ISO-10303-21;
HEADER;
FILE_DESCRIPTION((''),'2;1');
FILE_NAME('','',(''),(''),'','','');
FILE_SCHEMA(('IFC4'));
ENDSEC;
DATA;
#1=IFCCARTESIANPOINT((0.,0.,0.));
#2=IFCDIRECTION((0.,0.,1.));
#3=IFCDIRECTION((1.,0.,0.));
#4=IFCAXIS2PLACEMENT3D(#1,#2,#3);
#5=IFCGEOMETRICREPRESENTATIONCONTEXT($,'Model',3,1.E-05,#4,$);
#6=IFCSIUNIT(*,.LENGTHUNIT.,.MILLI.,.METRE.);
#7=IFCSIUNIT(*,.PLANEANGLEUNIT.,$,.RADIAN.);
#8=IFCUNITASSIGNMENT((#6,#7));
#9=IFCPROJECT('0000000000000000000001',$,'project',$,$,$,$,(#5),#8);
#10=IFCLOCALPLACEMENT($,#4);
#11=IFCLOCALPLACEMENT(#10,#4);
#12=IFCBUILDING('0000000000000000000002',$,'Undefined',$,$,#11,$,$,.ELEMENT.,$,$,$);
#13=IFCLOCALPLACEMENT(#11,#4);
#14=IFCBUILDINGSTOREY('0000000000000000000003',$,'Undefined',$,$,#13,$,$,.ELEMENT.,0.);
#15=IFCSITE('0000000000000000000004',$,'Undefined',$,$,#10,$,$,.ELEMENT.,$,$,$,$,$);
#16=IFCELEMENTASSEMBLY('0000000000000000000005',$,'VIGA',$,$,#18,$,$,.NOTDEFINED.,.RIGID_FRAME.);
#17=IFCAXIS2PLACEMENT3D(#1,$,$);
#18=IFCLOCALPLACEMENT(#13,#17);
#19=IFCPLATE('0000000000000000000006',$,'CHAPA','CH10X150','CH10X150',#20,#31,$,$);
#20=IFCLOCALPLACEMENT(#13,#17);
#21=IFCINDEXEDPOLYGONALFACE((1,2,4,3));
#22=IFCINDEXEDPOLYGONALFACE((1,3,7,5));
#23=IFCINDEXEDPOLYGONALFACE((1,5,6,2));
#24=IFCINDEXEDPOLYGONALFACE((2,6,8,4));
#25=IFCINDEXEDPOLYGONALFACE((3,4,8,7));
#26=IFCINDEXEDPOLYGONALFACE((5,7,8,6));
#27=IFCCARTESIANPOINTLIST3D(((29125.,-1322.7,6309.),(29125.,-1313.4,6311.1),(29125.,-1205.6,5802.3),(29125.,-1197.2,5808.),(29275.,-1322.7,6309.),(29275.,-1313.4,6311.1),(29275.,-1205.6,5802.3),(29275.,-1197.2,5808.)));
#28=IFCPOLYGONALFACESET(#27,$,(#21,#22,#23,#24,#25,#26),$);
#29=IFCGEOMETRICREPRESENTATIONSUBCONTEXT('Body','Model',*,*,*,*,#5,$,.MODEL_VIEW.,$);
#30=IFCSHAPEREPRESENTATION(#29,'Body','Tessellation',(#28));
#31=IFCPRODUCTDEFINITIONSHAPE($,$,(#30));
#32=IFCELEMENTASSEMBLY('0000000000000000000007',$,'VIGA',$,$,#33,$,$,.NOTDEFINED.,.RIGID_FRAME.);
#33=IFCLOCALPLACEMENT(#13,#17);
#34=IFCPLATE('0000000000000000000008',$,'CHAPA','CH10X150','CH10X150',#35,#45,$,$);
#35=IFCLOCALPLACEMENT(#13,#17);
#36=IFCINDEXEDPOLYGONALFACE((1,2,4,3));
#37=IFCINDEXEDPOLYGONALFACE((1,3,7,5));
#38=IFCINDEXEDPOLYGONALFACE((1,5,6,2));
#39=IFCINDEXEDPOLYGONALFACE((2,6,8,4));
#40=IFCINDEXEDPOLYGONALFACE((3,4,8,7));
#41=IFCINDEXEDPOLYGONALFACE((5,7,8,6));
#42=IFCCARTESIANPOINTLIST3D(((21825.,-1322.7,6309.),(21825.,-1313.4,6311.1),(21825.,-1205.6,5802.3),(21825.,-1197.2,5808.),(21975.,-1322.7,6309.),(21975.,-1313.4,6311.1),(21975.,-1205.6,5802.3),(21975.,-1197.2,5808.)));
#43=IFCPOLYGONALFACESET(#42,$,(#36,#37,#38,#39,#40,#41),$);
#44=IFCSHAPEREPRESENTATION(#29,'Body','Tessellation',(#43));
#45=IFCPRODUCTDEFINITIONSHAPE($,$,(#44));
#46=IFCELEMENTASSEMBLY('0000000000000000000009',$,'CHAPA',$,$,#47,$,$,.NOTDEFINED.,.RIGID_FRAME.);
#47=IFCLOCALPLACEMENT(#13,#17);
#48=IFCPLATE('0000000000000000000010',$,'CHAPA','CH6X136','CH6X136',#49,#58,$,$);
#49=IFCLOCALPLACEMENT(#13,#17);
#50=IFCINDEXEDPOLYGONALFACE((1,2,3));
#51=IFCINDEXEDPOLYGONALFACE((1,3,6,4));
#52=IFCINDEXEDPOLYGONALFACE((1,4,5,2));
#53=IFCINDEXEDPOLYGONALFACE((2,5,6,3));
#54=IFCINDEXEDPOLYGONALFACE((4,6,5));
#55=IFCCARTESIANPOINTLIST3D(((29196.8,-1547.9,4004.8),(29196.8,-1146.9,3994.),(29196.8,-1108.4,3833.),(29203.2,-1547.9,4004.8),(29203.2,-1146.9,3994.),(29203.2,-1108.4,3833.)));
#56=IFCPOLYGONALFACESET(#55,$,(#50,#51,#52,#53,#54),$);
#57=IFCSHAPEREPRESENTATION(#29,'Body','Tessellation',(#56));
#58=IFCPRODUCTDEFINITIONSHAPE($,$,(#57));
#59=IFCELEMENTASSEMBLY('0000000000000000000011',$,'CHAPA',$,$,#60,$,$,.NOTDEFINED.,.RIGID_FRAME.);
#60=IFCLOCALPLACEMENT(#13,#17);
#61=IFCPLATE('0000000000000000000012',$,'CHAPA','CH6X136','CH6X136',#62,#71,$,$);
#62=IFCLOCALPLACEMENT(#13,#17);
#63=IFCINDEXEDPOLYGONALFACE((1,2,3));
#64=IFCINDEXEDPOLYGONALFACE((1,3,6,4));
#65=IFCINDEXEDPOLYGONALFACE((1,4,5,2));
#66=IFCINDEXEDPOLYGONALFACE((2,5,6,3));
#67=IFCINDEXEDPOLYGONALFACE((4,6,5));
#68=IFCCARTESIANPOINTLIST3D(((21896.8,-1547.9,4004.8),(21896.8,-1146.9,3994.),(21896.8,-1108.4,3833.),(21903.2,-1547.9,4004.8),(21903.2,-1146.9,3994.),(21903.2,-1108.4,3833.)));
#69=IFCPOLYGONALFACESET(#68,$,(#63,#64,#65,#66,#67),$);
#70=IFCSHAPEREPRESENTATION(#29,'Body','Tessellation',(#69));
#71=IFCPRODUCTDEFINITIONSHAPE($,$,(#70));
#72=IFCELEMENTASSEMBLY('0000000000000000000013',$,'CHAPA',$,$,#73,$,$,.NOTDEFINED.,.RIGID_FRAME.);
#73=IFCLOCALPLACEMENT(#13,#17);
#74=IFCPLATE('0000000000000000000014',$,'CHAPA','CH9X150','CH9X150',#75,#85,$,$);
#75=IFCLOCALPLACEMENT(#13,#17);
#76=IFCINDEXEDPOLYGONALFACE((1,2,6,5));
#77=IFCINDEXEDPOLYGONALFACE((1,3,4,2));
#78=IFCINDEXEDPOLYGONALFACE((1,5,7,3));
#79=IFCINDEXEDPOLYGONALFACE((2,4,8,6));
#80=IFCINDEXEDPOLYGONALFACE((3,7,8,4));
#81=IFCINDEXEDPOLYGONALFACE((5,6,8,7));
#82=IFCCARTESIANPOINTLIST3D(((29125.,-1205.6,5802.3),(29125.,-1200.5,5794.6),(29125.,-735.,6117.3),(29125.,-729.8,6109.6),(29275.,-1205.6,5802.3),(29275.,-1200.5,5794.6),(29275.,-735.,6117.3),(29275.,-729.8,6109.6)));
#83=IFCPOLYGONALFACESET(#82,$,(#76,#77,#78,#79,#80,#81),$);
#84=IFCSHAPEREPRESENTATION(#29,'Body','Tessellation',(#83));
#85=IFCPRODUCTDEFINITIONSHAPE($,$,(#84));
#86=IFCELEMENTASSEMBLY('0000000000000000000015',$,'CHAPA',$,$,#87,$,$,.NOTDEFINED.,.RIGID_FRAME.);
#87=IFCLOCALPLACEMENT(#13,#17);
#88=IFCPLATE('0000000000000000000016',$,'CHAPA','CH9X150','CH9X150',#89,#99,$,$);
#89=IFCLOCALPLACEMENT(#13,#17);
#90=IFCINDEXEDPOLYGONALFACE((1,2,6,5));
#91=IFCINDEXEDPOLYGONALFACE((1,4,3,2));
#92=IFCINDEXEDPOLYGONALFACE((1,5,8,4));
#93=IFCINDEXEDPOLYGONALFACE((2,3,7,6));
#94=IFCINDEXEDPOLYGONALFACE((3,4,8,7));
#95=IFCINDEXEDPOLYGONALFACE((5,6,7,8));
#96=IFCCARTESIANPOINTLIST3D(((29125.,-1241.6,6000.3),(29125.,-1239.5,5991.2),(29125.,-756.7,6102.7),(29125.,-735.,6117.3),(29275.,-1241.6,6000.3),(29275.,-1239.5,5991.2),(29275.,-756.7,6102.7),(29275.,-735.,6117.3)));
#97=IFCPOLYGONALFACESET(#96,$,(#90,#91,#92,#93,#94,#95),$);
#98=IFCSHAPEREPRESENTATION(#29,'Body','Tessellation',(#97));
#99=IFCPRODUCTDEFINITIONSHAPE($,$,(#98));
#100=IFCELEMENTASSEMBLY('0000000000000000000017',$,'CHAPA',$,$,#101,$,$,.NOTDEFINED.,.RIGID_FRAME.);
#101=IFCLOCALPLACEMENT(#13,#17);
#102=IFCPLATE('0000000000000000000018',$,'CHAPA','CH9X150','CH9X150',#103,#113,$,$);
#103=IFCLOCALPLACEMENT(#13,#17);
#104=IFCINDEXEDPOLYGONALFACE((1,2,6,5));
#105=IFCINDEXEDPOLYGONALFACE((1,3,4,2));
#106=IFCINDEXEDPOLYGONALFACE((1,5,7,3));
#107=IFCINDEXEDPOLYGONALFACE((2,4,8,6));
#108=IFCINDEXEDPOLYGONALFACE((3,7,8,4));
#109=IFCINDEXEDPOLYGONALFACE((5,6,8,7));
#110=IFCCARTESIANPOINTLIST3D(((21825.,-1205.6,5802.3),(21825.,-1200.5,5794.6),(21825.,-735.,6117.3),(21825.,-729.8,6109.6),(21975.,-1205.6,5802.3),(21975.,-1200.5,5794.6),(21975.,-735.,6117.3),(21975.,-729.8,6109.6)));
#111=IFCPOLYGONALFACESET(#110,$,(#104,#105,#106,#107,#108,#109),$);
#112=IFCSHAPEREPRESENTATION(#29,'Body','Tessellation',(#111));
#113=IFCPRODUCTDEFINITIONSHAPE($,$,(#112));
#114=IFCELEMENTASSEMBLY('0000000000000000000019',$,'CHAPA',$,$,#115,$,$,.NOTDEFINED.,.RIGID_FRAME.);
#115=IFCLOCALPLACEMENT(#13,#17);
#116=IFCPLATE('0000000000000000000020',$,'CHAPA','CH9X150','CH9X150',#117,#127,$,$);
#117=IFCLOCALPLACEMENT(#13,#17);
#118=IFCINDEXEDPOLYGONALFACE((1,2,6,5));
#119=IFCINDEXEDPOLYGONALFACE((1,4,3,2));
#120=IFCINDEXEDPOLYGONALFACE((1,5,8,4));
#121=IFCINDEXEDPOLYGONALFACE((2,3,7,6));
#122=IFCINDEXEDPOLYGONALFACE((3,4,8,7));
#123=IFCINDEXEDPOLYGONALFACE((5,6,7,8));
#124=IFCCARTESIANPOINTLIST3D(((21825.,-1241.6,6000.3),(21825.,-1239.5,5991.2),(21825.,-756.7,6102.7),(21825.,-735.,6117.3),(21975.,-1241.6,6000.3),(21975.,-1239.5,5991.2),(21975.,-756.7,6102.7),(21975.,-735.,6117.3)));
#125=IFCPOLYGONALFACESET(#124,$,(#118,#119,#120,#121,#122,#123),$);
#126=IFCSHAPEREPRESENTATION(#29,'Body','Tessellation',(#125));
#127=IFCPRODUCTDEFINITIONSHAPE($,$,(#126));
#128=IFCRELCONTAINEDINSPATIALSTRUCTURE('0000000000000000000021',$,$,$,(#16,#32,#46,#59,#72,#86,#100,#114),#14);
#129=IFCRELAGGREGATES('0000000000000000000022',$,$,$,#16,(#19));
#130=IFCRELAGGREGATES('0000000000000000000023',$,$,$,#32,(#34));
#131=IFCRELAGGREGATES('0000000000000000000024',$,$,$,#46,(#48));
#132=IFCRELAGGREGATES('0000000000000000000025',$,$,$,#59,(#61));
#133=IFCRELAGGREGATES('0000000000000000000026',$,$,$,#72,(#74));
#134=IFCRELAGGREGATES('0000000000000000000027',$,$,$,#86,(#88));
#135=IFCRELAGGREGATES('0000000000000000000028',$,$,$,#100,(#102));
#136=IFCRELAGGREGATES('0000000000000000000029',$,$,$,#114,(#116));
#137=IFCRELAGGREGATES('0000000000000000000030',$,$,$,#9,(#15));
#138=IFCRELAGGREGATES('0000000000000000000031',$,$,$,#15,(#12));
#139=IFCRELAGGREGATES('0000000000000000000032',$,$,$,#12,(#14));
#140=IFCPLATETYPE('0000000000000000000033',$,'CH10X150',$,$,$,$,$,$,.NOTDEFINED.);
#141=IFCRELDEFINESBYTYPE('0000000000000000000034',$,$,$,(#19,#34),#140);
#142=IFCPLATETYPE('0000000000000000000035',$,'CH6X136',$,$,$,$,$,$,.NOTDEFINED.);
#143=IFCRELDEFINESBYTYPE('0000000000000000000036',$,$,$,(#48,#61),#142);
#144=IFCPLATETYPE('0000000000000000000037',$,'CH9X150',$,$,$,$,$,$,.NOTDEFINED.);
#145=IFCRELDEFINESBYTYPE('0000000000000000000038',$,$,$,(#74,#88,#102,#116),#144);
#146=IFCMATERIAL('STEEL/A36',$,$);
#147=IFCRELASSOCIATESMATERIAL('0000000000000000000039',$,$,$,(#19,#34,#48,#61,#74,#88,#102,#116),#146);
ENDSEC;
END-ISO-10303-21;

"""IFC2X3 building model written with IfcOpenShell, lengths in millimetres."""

from ifc_helpers import new_model, si_unit, frame, origin_with_axes, place, context, subcontext, project, spatial, polyline, outline, extrude, clip, halfspace, material, type_object, element, aggregate, save


model = new_model("IFC2X3")

# Units and contexts
model_context = context("Model", 3, precision=1e-05, world=origin_with_axes())
body_context = subcontext(model_context, "Body", "Model", "MODEL_VIEW")
ifc_project = project(units=[si_unit("LENGTHUNIT", "METRE", prefix="MILLI"), si_unit("PLANEANGLEUNIT", "RADIAN")], contexts=[model_context])

# Site, building, storey
site_placement = place(None, origin_with_axes())
site = spatial("IfcSite", under=ifc_project, at=site_placement, Name="Undefined", CompositionType="ELEMENT")
building_placement = place(site_placement, origin_with_axes())
building = spatial("IfcBuilding", under=site, at=building_placement, Name="Undefined", CompositionType="ELEMENT")
storey_placement = place(building_placement, origin_with_axes())
storey = spatial("IfcBuildingStorey", under=building, at=storey_placement, Name="Undefined", CompositionType="ELEMENT", Elevation=0.0)

# Element assembly
assembly_1_placement = place(storey_placement, origin_with_axes())
assembly_1 = element("IfcElementAssembly", 1, at=assembly_1_placement, inside=storey, Name="VIGA", AssemblyPlace="NOTDEFINED", PredefinedType="RIGID_FRAME")

# Plate
ifc_material_1 = material(Name="STEEL/A36")
plate_type_1 = type_object("IfcPlateType", Name="CH10X150", PredefinedType="NOTDEFINED")
plate_1_placement = place(assembly_1_placement, frame((29275.0, -1318.1, 6310.1), z_axis=(0.0, 0.97433, 0.225124), x_axis=(0.0, 0.225124, -0.97433)))
plate_1 = element("IfcPlate", 2, at=plate_1_placement, type_object=plate_type_1, material=ifc_material_1, Name="CHAPA", Description="CH10X150", ObjectType="CH10X150", context=body_context, shape_type="Clipping", body=[
    clip(extrude(outline(polyline([(0.0, 0.0), (520.0, 0.0), (520.0, 150.0), (0.0, 150.0), (0.0, 0.0)])), frame((0.0, 0.0, -4.8), z_axis=(0.0, 0.0, 1.0), x_axis=(1.0, 0.0, 0.0)), (0.0, 0.0, 1.0), 9.5), halfspace(frame((516.4, -500.0, 4.8), z_axis=(0.934951, 0.0, 0.354778), x_axis=(0.0, 1.0, 0.0)), False)),
])
aggregate(assembly_1, [plate_1])

# Element assemblies, plates
assembly_2_placement = place(storey_placement, origin_with_axes())
assembly_2 = element("IfcElementAssembly", 3, at=assembly_2_placement, inside=storey, Name="VIGA", AssemblyPlace="NOTDEFINED", PredefinedType="RIGID_FRAME")
plate_2_placement = place(assembly_2_placement, frame((21975.0, -1318.1, 6310.1), z_axis=(0.0, 0.97433, 0.225124), x_axis=(0.0, 0.225124, -0.97433)))
plate_2 = element("IfcPlate", 4, at=plate_2_placement, type_object=plate_type_1, material=ifc_material_1, Name="CHAPA", Description="CH10X150", ObjectType="CH10X150", context=body_context, shape_type="Clipping", body=[
    clip(extrude(outline(polyline([(0.0, 0.0), (520.0, 0.0), (520.0, 150.0), (0.0, 150.0), (0.0, 0.0)])), frame((0.0, 0.0, -4.8), z_axis=(0.0, 0.0, 1.0), x_axis=(1.0, 0.0, 0.0)), (0.0, 0.0, 1.0), 9.5), halfspace(frame((516.4, -500.0, 4.8), z_axis=(0.934951, 0.0, 0.354778), x_axis=(0.0, 1.0, 0.0)), False)),
])
aggregate(assembly_2, [plate_2])
assembly_3_placement = place(storey_placement, origin_with_axes())
assembly_3 = element("IfcElementAssembly", 5, at=assembly_3_placement, inside=storey, Name="CHAPA", AssemblyPlace="NOTDEFINED", PredefinedType="RIGID_FRAME")
plate_type_2 = type_object("IfcPlateType", Name="CH6X136", PredefinedType="NOTDEFINED")
plate_3_placement = place(assembly_3_placement, frame((29200.0, -1146.9, 3994.0), z_axis=(1.0, 0.0, 0.0), x_axis=(0.0, -0.999636, 0.026972)))
plate_3 = element("IfcPlate", 6, at=plate_3_placement, type_object=plate_type_2, material=ifc_material_1, Name="CHAPA", Description="CH6X136", ObjectType="CH6X136", context=body_context, shape_type="SweptSolid", body=[
    extrude(outline(polyline([(0.0, 0.0), (401.1, 0.0), (-42.8, 159.9), (0.0, 0.0)])), frame((0.0, 0.0, -3.1), z_axis=(0.0, 0.0, 1.0), x_axis=(1.0, 0.0, 0.0)), (0.0, 0.0, 1.0), 6.3),
])
aggregate(assembly_3, [plate_3])
assembly_4_placement = place(storey_placement, origin_with_axes())
assembly_4 = element("IfcElementAssembly", 7, at=assembly_4_placement, inside=storey, Name="CHAPA", AssemblyPlace="NOTDEFINED", PredefinedType="RIGID_FRAME")
plate_4_placement = place(assembly_4_placement, frame((21900.0, -1146.9, 3994.0), z_axis=(1.0, 0.0, 0.0), x_axis=(0.0, -0.999636, 0.026972)))
plate_4 = element("IfcPlate", 8, at=plate_4_placement, type_object=plate_type_2, material=ifc_material_1, Name="CHAPA", Description="CH6X136", ObjectType="CH6X136", context=body_context, shape_type="SweptSolid", body=[
    extrude(outline(polyline([(0.0, 0.0), (401.1, 0.0), (-42.8, 159.9), (0.0, 0.0)])), frame((0.0, 0.0, -3.1), z_axis=(0.0, 0.0, 1.0), x_axis=(1.0, 0.0, 0.0)), (0.0, 0.0, 1.0), 6.3),
])
aggregate(assembly_4, [plate_4])
assembly_5_placement = place(storey_placement, origin_with_axes())
assembly_5 = element("IfcElementAssembly", 9, at=assembly_5_placement, inside=storey, Name="CHAPA", AssemblyPlace="NOTDEFINED", PredefinedType="RIGID_FRAME")
plate_type_3 = type_object("IfcPlateType", Name="CH9X150", PredefinedType="NOTDEFINED")
plate_5_placement = place(assembly_5_placement, frame((29275.0, -732.4, 6113.5), z_axis=(0.0, -0.55615, 0.831082), x_axis=(-1.0, 0.0, 0.0)))
plate_5 = element("IfcPlate", 10, at=plate_5_placement, type_object=plate_type_3, material=ifc_material_1, Name="CHAPA", Description="CH9X150", ObjectType="CH9X150", context=body_context, shape_type="SweptSolid", body=[
    extrude(outline(polyline([(0.0, 0.0), (150.0, 0.0), (150.0, 566.3), (0.0, 566.3), (0.0, 0.0)])), frame((0.0, 0.0, -4.7), z_axis=(0.0, 0.0, 1.0), x_axis=(1.0, 0.0, 0.0)), (0.0, 0.0, 1.0), 9.3),
])
aggregate(assembly_5, [plate_5])
assembly_6_placement = place(storey_placement, origin_with_axes())
assembly_6 = element("IfcElementAssembly", 11, at=assembly_6_placement, inside=storey, Name="CHAPA", AssemblyPlace="NOTDEFINED", PredefinedType="RIGID_FRAME")
plate_6_placement = place(assembly_6_placement, frame((29275.0, -1240.6, 5995.7), z_axis=(0.0, -0.225124, 0.97433), x_axis=(0.0, 0.97433, 0.225124)))
plate_6 = element("IfcPlate", 12, at=plate_6_placement, type_object=plate_type_3, material=ifc_material_1, Name="CHAPA", Description="CH9X150", ObjectType="CH9X150", context=body_context, shape_type="Clipping", body=[
    clip(extrude(outline(polyline([(0.0, 0.0), (520.0, 0.0), (520.0, 150.0), (0.0, 150.0), (0.0, 0.0)])), frame((0.0, 0.0, -4.7), z_axis=(0.0, 0.0, 1.0), x_axis=(1.0, 0.0, 0.0)), (0.0, 0.0, 1.0), 9.3), halfspace(frame((520.0, -500.0, 4.7), z_axis=(0.354778, 0.0, -0.934951), x_axis=(0.0, 1.0, 0.0)), False)),
])
aggregate(assembly_6, [plate_6])
assembly_7_placement = place(storey_placement, origin_with_axes())
assembly_7 = element("IfcElementAssembly", 13, at=assembly_7_placement, inside=storey, Name="CHAPA", AssemblyPlace="NOTDEFINED", PredefinedType="RIGID_FRAME")
plate_7_placement = place(assembly_7_placement, frame((21975.0, -732.4, 6113.5), z_axis=(0.0, -0.55615, 0.831082), x_axis=(-1.0, 0.0, 0.0)))
plate_7 = element("IfcPlate", 14, at=plate_7_placement, type_object=plate_type_3, material=ifc_material_1, Name="CHAPA", Description="CH9X150", ObjectType="CH9X150", context=body_context, shape_type="SweptSolid", body=[
    extrude(outline(polyline([(0.0, 0.0), (150.0, 0.0), (150.0, 566.3), (0.0, 566.3), (0.0, 0.0)])), frame((0.0, 0.0, -4.7), z_axis=(0.0, 0.0, 1.0), x_axis=(1.0, 0.0, 0.0)), (0.0, 0.0, 1.0), 9.3),
])
aggregate(assembly_7, [plate_7])
assembly_8_placement = place(storey_placement, origin_with_axes())
assembly_8 = element("IfcElementAssembly", 15, at=assembly_8_placement, inside=storey, Name="CHAPA", AssemblyPlace="NOTDEFINED", PredefinedType="RIGID_FRAME")
plate_8_placement = place(assembly_8_placement, frame((21975.0, -1240.6, 5995.7), z_axis=(0.0, -0.225124, 0.97433), x_axis=(0.0, 0.97433, 0.225124)))
plate_8 = element("IfcPlate", 16, at=plate_8_placement, type_object=plate_type_3, material=ifc_material_1, Name="CHAPA", Description="CH9X150", ObjectType="CH9X150", context=body_context, shape_type="Clipping", body=[
    clip(extrude(outline(polyline([(0.0, 0.0), (520.0, 0.0), (520.0, 150.0), (0.0, 150.0), (0.0, 0.0)])), frame((0.0, 0.0, -4.7), z_axis=(0.0, 0.0, 1.0), x_axis=(1.0, 0.0, 0.0)), (0.0, 0.0, 1.0), 9.3), halfspace(frame((520.0, -500.0, 4.7), z_axis=(0.354778, 0.0, -0.934951), x_axis=(0.0, 1.0, 0.0)), False)),
])
aggregate(assembly_8, [plate_8])

save(model, "model.ifc")
